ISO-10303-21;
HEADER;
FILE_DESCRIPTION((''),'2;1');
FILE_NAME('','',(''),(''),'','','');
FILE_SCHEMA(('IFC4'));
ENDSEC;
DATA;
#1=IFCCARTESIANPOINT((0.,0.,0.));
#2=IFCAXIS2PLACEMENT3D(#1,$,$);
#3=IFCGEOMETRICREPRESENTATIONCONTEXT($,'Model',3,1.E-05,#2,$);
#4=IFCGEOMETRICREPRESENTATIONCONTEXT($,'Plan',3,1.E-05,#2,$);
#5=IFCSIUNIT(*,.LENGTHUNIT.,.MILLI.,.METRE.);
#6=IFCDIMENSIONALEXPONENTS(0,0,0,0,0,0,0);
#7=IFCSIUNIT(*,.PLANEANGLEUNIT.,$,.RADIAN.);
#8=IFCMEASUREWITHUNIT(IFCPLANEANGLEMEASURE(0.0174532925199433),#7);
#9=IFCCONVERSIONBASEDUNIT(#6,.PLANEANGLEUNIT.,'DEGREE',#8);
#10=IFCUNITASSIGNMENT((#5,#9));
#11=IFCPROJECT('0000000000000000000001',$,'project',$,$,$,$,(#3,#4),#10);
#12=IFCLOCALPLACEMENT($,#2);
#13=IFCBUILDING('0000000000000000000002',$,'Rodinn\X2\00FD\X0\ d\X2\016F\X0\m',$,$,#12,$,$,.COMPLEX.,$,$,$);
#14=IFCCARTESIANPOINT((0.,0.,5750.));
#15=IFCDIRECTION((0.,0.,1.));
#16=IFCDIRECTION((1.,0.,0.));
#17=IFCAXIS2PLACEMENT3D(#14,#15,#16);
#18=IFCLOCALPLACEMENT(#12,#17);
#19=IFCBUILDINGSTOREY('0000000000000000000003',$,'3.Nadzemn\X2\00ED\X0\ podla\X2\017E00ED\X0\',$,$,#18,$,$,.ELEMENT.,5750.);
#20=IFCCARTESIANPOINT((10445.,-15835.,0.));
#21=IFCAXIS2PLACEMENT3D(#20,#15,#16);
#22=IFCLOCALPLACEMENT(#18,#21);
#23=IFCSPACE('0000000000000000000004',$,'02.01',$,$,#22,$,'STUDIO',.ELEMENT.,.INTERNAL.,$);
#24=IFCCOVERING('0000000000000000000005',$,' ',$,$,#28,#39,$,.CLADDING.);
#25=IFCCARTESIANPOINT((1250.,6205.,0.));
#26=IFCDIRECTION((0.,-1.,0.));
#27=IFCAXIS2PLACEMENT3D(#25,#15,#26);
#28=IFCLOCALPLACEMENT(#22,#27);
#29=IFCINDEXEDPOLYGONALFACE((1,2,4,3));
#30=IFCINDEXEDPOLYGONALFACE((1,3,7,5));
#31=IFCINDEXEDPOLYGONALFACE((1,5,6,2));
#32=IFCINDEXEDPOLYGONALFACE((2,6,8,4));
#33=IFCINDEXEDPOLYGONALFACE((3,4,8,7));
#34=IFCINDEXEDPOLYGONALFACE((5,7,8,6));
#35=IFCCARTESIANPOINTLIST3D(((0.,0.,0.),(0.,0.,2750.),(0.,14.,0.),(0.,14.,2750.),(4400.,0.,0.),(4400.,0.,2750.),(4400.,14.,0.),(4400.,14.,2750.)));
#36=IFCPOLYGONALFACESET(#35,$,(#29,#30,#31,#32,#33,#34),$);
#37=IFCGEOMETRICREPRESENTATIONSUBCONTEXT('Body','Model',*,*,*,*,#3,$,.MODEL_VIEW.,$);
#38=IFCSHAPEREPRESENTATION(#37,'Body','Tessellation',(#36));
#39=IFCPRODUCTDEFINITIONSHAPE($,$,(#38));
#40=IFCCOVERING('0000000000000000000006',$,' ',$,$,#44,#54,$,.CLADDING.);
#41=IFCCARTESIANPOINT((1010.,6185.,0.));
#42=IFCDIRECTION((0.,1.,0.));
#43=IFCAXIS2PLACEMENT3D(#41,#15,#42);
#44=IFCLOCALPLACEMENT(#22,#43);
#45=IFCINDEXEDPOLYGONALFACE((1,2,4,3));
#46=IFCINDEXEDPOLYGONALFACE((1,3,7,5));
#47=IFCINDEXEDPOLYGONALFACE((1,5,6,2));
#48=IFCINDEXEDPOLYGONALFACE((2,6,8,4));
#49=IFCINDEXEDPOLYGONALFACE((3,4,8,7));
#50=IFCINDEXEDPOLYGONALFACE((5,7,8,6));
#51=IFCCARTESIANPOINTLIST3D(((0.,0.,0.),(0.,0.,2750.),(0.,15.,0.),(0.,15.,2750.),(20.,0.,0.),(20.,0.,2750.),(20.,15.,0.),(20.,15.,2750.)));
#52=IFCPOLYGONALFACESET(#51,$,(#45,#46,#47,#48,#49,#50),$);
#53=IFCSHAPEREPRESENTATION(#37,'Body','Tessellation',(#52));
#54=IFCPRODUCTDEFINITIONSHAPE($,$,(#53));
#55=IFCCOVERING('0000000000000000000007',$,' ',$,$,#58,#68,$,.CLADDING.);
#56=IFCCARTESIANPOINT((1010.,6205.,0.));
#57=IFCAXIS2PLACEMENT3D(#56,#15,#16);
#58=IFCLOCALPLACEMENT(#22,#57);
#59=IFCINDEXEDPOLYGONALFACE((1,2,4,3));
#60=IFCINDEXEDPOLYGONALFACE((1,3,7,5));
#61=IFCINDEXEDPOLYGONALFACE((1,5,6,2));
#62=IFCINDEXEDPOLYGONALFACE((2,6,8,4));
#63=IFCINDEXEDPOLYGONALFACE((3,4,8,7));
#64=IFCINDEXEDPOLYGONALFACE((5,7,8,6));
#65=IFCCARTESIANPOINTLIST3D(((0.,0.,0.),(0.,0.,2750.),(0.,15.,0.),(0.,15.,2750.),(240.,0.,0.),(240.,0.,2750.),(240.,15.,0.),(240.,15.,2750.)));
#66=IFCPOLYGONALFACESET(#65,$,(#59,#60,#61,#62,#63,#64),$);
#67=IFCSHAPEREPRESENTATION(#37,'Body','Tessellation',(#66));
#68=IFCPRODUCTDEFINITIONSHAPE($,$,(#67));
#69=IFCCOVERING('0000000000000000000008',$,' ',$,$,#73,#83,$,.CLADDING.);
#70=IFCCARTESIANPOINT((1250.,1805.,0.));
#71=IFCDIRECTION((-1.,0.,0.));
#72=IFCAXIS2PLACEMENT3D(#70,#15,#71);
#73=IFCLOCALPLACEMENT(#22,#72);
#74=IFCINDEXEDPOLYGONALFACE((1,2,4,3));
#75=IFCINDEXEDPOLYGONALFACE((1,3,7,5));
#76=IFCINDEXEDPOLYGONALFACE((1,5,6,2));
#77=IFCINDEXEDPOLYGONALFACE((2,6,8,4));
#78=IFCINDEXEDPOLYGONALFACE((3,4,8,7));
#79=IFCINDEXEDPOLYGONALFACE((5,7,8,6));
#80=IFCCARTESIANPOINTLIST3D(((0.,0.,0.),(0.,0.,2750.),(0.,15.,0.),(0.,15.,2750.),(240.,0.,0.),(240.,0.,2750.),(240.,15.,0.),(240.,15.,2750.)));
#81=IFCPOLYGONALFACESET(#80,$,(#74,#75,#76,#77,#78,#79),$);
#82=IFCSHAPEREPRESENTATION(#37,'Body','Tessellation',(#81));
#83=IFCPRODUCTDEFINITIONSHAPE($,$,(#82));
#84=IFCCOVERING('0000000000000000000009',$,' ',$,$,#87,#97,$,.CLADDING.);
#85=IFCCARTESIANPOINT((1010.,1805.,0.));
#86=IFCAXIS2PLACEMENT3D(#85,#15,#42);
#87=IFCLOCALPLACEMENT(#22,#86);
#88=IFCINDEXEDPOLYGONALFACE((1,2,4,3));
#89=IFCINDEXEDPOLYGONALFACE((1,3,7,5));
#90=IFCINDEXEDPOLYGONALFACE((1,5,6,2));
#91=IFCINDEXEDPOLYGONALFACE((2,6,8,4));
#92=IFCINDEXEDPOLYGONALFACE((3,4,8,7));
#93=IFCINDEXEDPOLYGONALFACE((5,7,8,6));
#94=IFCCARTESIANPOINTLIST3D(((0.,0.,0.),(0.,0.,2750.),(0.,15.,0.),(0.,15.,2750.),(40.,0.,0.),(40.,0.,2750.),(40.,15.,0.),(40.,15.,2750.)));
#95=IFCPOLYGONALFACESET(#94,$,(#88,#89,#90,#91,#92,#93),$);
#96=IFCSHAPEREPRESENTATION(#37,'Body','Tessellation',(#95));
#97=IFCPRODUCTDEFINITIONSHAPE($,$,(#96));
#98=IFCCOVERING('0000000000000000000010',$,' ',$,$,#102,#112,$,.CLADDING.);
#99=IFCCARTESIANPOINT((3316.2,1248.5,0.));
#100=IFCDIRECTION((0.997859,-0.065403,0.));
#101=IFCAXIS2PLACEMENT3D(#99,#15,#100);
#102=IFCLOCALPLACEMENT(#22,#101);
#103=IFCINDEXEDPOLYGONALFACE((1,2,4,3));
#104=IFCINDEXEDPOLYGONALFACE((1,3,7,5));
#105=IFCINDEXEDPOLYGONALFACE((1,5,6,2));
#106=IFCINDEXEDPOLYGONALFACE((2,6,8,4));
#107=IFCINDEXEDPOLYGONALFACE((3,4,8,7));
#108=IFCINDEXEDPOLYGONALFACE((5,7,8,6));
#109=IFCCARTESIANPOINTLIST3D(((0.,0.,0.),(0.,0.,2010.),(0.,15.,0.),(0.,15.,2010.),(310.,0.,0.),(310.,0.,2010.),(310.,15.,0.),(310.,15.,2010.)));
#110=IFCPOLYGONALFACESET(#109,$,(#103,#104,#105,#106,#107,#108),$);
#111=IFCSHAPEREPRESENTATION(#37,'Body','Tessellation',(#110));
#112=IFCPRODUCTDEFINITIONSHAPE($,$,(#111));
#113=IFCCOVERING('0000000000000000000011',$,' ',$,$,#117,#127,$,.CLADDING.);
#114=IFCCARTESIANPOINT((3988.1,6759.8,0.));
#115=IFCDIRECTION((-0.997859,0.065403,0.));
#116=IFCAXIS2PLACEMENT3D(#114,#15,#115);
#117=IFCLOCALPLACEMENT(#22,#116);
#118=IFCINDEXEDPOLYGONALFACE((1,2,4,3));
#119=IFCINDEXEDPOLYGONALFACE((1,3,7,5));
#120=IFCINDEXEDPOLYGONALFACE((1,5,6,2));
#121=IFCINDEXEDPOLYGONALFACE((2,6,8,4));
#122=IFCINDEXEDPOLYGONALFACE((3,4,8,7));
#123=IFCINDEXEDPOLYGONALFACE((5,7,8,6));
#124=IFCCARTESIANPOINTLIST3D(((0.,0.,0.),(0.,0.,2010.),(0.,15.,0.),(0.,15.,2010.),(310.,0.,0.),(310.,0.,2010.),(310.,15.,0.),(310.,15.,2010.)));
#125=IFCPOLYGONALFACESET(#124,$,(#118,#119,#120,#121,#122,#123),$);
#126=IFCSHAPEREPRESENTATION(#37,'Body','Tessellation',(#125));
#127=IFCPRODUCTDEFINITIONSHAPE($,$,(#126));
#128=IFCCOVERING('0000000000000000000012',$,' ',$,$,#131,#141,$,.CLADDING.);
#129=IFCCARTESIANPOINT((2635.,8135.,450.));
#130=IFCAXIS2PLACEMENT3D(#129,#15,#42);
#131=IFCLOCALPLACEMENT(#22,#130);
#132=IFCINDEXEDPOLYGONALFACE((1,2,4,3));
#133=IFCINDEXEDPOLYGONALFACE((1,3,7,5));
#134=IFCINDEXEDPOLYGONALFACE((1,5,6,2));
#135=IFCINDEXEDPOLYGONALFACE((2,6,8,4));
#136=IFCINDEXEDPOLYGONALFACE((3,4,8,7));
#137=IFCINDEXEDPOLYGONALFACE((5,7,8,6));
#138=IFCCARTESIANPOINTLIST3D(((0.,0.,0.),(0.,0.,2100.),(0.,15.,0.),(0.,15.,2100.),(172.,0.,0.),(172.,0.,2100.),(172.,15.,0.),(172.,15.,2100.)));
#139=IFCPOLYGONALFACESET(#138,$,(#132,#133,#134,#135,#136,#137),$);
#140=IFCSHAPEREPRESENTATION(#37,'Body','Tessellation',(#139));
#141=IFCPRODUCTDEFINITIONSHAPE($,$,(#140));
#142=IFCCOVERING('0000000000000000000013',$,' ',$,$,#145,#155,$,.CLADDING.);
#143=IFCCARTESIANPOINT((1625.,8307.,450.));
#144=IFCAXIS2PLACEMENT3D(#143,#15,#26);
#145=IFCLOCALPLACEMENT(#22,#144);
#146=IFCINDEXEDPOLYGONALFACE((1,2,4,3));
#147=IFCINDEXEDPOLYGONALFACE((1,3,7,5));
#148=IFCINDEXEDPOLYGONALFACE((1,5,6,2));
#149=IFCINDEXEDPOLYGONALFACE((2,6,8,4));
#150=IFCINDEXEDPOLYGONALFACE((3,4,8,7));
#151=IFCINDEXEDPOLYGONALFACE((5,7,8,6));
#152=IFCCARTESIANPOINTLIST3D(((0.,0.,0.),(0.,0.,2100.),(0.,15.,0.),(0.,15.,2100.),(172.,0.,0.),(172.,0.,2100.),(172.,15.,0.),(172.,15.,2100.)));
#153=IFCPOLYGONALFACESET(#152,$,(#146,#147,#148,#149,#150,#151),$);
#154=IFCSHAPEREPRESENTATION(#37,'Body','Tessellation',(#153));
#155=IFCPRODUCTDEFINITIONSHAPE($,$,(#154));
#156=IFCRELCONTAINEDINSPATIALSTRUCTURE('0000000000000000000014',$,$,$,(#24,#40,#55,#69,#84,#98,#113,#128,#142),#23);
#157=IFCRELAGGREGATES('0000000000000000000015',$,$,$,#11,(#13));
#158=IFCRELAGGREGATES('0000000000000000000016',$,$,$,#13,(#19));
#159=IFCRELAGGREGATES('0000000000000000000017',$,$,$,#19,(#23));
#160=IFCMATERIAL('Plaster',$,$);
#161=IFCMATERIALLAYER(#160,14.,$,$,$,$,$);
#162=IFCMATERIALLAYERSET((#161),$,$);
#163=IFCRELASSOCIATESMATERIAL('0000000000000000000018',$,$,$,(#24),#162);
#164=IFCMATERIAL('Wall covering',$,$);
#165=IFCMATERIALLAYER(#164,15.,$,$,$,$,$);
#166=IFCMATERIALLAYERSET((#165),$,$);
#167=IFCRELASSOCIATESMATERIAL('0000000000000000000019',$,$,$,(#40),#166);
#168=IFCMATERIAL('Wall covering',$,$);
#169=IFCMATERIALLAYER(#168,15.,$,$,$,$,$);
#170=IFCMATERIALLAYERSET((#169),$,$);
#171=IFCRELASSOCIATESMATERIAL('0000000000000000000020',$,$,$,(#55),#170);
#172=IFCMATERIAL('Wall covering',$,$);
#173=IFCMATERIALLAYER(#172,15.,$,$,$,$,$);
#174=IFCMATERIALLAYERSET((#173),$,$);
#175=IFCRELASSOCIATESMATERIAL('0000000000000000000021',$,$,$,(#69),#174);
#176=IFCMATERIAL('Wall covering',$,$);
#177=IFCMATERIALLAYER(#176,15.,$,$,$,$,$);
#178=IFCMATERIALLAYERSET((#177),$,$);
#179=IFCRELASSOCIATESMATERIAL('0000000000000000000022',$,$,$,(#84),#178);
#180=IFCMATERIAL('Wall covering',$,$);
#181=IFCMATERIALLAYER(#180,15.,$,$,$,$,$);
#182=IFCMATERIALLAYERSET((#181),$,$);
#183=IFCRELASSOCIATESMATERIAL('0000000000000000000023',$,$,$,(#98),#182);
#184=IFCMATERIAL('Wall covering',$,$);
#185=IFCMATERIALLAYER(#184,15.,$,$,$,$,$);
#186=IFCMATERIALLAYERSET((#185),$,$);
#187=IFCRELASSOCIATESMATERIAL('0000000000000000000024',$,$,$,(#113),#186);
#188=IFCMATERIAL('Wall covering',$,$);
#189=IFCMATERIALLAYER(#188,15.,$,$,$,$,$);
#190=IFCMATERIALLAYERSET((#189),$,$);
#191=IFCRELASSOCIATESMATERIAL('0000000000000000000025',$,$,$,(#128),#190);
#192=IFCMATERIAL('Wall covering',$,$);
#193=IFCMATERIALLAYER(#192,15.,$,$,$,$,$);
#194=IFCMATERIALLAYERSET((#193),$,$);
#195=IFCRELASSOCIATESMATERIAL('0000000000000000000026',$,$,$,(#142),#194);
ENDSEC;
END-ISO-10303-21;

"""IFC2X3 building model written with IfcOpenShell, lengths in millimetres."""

from ifc_helpers import new_model, entity, si_unit, converted_unit, frame, frame_2d, origin, place, context, subcontext, project, spatial, rectangle, extrude, material, layer, layer_set, layer_usage, element, save


model = new_model("IFC2X3")

# Units and contexts
model_context = context("Model", 3, precision=1e-05, world=origin())
plan_context = context("Plan", 3, precision=1e-05, world=origin())
body_context = subcontext(model_context, "Body", "Model", "MODEL_VIEW")
ifc_project = project(units=[si_unit("LENGTHUNIT", "METRE", prefix="MILLI"), converted_unit("PLANEANGLEUNIT", "DEGREE", entity("IfcPlaneAngleMeasure", 0.0174532925199433), si_unit("PLANEANGLEUNIT", "RADIAN"), dimensions=[0, 0, 0, 0, 0, 0, 0])], contexts=[model_context, plan_context])

# Building, storey
building_placement = place(None, origin())
building = spatial("IfcBuilding", under=ifc_project, at=building_placement, Name="Rodinný dům", CompositionType="COMPLEX")
storey_placement = place(building_placement, frame((0.0, 0.0, 5750.0), z_axis=(0.0, 0.0, 1.0), x_axis=(1.0, 0.0, 0.0)))
storey = spatial("IfcBuildingStorey", under=building, at=storey_placement, Name="3.Nadzemní podlaží", CompositionType="ELEMENT", Elevation=5750.0)

# Shared definitions
space_1_placement = place(storey_placement, frame((10445.0, -15835.0, 0.0), z_axis=(0.0, 0.0, 1.0), x_axis=(1.0, 0.0, 0.0)))
space_1 = spatial("IfcSpace", under=storey, at=space_1_placement, Name="02.01", LongName="STUDIO", CompositionType="ELEMENT", InteriorOrExteriorSpace="INTERNAL")

# Coverings
ifc_material_1 = material(Name="Plaster")
ifc_layer_1 = layer(ifc_material_1, 14.0)
ifc_layer_set_1 = layer_set([ifc_layer_1])
ifc_layer_usage_1 = layer_usage(ifc_layer_set_1, "AXIS3", "POSITIVE", 0.0)
covering_1_placement = place(space_1_placement, frame((1250.0, 6205.0, 0.0), z_axis=(0.0, 0.0, 1.0), x_axis=(0.0, -1.0, 0.0)))
element("IfcCovering", 1, at=covering_1_placement, inside=space_1, material=ifc_layer_usage_1, Name=" ", PredefinedType="CLADDING", context=body_context, shape_type="SweptSolid", body=[
    extrude(rectangle(XDim=4400.0, YDim=2750.0, at=frame_2d((-2200.0, -1375.0), x_axis=(-1.0, 0.0))), frame((4400.0, 0.0, 0.0), z_axis=(0.0, 1.0, 0.0), x_axis=(1.0, 0.0, 0.0)), (0.0, 0.0, 1.0), 14.0),
])
ifc_material_2 = material(Name="Wall covering")
ifc_layer_2 = layer(ifc_material_2, 15.0)
ifc_layer_set_2 = layer_set([ifc_layer_2])
ifc_layer_usage_2 = layer_usage(ifc_layer_set_2, "AXIS3", "POSITIVE", 0.0)
covering_2_placement = place(space_1_placement, frame((1010.0, 6185.0, 0.0), z_axis=(0.0, 0.0, 1.0), x_axis=(0.0, 1.0, 0.0)))
element("IfcCovering", 2, at=covering_2_placement, inside=space_1, material=ifc_layer_usage_2, Name=" ", PredefinedType="CLADDING", context=body_context, shape_type="SweptSolid", body=[
    extrude(rectangle(XDim=2750.0, YDim=20.0, at=frame_2d((-10.0, 1375.0), x_axis=(0.0, 1.0))), frame((20.0, 0.0, 2750.0), z_axis=(0.0, 1.0, 0.0), x_axis=(1.0, 0.0, 0.0)), (0.0, 0.0, 1.0), 15.0),
])
ifc_material_3 = material(Name="Wall covering")
ifc_layer_3 = layer(ifc_material_3, 15.0)
ifc_layer_set_3 = layer_set([ifc_layer_3])
ifc_layer_usage_3 = layer_usage(ifc_layer_set_3, "AXIS3", "POSITIVE", 0.0)
covering_3_placement = place(space_1_placement, frame((1010.0, 6205.0, 0.0), z_axis=(0.0, 0.0, 1.0), x_axis=(1.0, 0.0, 0.0)))
element("IfcCovering", 3, at=covering_3_placement, inside=space_1, material=ifc_layer_usage_3, Name=" ", PredefinedType="CLADDING", context=body_context, shape_type="SweptSolid", body=[
    extrude(rectangle(XDim=2750.0, YDim=240.0, at=frame_2d((-120.0, 1375.0), x_axis=(0.0, 1.0))), frame((240.0, 0.0, 2750.0), z_axis=(0.0, 1.0, 0.0), x_axis=(1.0, 0.0, 0.0)), (0.0, 0.0, 1.0), 15.0),
])
ifc_material_4 = material(Name="Wall covering")
ifc_layer_4 = layer(ifc_material_4, 15.0)
ifc_layer_set_4 = layer_set([ifc_layer_4])
ifc_layer_usage_4 = layer_usage(ifc_layer_set_4, "AXIS3", "POSITIVE", 0.0)
covering_4_placement = place(space_1_placement, frame((1250.0, 1805.0, 0.0), z_axis=(0.0, 0.0, 1.0), x_axis=(-1.0, 0.0, 0.0)))
element("IfcCovering", 4, at=covering_4_placement, inside=space_1, material=ifc_layer_usage_4, Name=" ", PredefinedType="CLADDING", context=body_context, shape_type="SweptSolid", body=[
    extrude(rectangle(XDim=2750.0, YDim=240.0, at=frame_2d((-120.0, 1375.0), x_axis=(0.0, 1.0))), frame((240.0, 0.0, 2750.0), z_axis=(0.0, 1.0, 0.0), x_axis=(1.0, 0.0, 0.0)), (0.0, 0.0, 1.0), 15.0),
])
ifc_material_5 = material(Name="Wall covering")
ifc_layer_5 = layer(ifc_material_5, 15.0)
ifc_layer_set_5 = layer_set([ifc_layer_5])
ifc_layer_usage_5 = layer_usage(ifc_layer_set_5, "AXIS3", "POSITIVE", 0.0)
covering_5_placement = place(space_1_placement, frame((1010.0, 1805.0, 0.0), z_axis=(0.0, 0.0, 1.0), x_axis=(0.0, 1.0, 0.0)))
element("IfcCovering", 5, at=covering_5_placement, inside=space_1, material=ifc_layer_usage_5, Name=" ", PredefinedType="CLADDING", context=body_context, shape_type="SweptSolid", body=[
    extrude(rectangle(XDim=2750.0, YDim=40.0, at=frame_2d((-20.0, 1375.0), x_axis=(0.0, 1.0))), frame((40.0, 0.0, 2750.0), z_axis=(0.0, 1.0, 0.0), x_axis=(1.0, 0.0, 0.0)), (0.0, 0.0, 1.0), 15.0),
])
ifc_material_6 = material(Name="Wall covering")
ifc_layer_6 = layer(ifc_material_6, 15.0)
ifc_layer_set_6 = layer_set([ifc_layer_6])
ifc_layer_usage_6 = layer_usage(ifc_layer_set_6, "AXIS3", "POSITIVE", 0.0)
covering_6_placement = place(space_1_placement, frame((3316.2, 1248.5, 0.0), z_axis=(0.0, 0.0, 1.0), x_axis=(0.997859, -0.065403, 0.0)))
element("IfcCovering", 6, at=covering_6_placement, inside=space_1, material=ifc_layer_usage_6, Name=" ", PredefinedType="CLADDING", context=body_context, shape_type="SweptSolid", body=[
    extrude(rectangle(XDim=2010.0, YDim=310.0, at=frame_2d((-155.0, 1005.0), x_axis=(0.0, 1.0))), frame((310.0, 0.0, 2010.0), z_axis=(0.0, 1.0, 0.0), x_axis=(1.0, 0.0, 0.0)), (0.0, 0.0, 1.0), 15.0),
])
ifc_material_7 = material(Name="Wall covering")
ifc_layer_7 = layer(ifc_material_7, 15.0)
ifc_layer_set_7 = layer_set([ifc_layer_7])
ifc_layer_usage_7 = layer_usage(ifc_layer_set_7, "AXIS3", "POSITIVE", 0.0)
covering_7_placement = place(space_1_placement, frame((3988.1, 6759.8, 0.0), z_axis=(0.0, 0.0, 1.0), x_axis=(-0.997859, 0.065403, 0.0)))
element("IfcCovering", 7, at=covering_7_placement, inside=space_1, material=ifc_layer_usage_7, Name=" ", PredefinedType="CLADDING", context=body_context, shape_type="SweptSolid", body=[
    extrude(rectangle(XDim=2010.0, YDim=310.0, at=frame_2d((-155.0, 1005.0), x_axis=(0.0, 1.0))), frame((310.0, 0.0, 2010.0), z_axis=(0.0, 1.0, 0.0), x_axis=(1.0, 0.0, 0.0)), (0.0, 0.0, 1.0), 15.0),
])
ifc_material_8 = material(Name="Wall covering")
ifc_layer_8 = layer(ifc_material_8, 15.0)
ifc_layer_set_8 = layer_set([ifc_layer_8])
ifc_layer_usage_8 = layer_usage(ifc_layer_set_8, "AXIS3", "POSITIVE", 0.0)
covering_8_placement = place(space_1_placement, frame((2635.0, 8135.0, 450.0), z_axis=(0.0, 0.0, 1.0), x_axis=(0.0, 1.0, 0.0)))
element("IfcCovering", 8, at=covering_8_placement, inside=space_1, material=ifc_layer_usage_8, Name=" ", PredefinedType="CLADDING", context=body_context, shape_type="SweptSolid", body=[
    extrude(rectangle(XDim=2100.0, YDim=172.0, at=frame_2d((-86.0, 1050.0), x_axis=(0.0, 1.0))), frame((172.0, 0.0, 2100.0), z_axis=(0.0, 1.0, 0.0), x_axis=(1.0, 0.0, 0.0)), (0.0, 0.0, 1.0), 15.0),
])
ifc_material_9 = material(Name="Wall covering")
ifc_layer_9 = layer(ifc_material_9, 15.0)
ifc_layer_set_9 = layer_set([ifc_layer_9])
ifc_layer_usage_9 = layer_usage(ifc_layer_set_9, "AXIS3", "POSITIVE", 0.0)
covering_9_placement = place(space_1_placement, frame((1625.0, 8307.0, 450.0), z_axis=(0.0, 0.0, 1.0), x_axis=(0.0, -1.0, 0.0)))
element("IfcCovering", 9, at=covering_9_placement, inside=space_1, material=ifc_layer_usage_9, Name=" ", PredefinedType="CLADDING", context=body_context, shape_type="SweptSolid", body=[
    extrude(rectangle(XDim=2100.0, YDim=172.0, at=frame_2d((-86.0, 1050.0), x_axis=(0.0, 1.0))), frame((172.0, 0.0, 2100.0), z_axis=(0.0, 1.0, 0.0), x_axis=(1.0, 0.0, 0.0)), (0.0, 0.0, 1.0), 15.0),
])

save(model, "model.ifc")
